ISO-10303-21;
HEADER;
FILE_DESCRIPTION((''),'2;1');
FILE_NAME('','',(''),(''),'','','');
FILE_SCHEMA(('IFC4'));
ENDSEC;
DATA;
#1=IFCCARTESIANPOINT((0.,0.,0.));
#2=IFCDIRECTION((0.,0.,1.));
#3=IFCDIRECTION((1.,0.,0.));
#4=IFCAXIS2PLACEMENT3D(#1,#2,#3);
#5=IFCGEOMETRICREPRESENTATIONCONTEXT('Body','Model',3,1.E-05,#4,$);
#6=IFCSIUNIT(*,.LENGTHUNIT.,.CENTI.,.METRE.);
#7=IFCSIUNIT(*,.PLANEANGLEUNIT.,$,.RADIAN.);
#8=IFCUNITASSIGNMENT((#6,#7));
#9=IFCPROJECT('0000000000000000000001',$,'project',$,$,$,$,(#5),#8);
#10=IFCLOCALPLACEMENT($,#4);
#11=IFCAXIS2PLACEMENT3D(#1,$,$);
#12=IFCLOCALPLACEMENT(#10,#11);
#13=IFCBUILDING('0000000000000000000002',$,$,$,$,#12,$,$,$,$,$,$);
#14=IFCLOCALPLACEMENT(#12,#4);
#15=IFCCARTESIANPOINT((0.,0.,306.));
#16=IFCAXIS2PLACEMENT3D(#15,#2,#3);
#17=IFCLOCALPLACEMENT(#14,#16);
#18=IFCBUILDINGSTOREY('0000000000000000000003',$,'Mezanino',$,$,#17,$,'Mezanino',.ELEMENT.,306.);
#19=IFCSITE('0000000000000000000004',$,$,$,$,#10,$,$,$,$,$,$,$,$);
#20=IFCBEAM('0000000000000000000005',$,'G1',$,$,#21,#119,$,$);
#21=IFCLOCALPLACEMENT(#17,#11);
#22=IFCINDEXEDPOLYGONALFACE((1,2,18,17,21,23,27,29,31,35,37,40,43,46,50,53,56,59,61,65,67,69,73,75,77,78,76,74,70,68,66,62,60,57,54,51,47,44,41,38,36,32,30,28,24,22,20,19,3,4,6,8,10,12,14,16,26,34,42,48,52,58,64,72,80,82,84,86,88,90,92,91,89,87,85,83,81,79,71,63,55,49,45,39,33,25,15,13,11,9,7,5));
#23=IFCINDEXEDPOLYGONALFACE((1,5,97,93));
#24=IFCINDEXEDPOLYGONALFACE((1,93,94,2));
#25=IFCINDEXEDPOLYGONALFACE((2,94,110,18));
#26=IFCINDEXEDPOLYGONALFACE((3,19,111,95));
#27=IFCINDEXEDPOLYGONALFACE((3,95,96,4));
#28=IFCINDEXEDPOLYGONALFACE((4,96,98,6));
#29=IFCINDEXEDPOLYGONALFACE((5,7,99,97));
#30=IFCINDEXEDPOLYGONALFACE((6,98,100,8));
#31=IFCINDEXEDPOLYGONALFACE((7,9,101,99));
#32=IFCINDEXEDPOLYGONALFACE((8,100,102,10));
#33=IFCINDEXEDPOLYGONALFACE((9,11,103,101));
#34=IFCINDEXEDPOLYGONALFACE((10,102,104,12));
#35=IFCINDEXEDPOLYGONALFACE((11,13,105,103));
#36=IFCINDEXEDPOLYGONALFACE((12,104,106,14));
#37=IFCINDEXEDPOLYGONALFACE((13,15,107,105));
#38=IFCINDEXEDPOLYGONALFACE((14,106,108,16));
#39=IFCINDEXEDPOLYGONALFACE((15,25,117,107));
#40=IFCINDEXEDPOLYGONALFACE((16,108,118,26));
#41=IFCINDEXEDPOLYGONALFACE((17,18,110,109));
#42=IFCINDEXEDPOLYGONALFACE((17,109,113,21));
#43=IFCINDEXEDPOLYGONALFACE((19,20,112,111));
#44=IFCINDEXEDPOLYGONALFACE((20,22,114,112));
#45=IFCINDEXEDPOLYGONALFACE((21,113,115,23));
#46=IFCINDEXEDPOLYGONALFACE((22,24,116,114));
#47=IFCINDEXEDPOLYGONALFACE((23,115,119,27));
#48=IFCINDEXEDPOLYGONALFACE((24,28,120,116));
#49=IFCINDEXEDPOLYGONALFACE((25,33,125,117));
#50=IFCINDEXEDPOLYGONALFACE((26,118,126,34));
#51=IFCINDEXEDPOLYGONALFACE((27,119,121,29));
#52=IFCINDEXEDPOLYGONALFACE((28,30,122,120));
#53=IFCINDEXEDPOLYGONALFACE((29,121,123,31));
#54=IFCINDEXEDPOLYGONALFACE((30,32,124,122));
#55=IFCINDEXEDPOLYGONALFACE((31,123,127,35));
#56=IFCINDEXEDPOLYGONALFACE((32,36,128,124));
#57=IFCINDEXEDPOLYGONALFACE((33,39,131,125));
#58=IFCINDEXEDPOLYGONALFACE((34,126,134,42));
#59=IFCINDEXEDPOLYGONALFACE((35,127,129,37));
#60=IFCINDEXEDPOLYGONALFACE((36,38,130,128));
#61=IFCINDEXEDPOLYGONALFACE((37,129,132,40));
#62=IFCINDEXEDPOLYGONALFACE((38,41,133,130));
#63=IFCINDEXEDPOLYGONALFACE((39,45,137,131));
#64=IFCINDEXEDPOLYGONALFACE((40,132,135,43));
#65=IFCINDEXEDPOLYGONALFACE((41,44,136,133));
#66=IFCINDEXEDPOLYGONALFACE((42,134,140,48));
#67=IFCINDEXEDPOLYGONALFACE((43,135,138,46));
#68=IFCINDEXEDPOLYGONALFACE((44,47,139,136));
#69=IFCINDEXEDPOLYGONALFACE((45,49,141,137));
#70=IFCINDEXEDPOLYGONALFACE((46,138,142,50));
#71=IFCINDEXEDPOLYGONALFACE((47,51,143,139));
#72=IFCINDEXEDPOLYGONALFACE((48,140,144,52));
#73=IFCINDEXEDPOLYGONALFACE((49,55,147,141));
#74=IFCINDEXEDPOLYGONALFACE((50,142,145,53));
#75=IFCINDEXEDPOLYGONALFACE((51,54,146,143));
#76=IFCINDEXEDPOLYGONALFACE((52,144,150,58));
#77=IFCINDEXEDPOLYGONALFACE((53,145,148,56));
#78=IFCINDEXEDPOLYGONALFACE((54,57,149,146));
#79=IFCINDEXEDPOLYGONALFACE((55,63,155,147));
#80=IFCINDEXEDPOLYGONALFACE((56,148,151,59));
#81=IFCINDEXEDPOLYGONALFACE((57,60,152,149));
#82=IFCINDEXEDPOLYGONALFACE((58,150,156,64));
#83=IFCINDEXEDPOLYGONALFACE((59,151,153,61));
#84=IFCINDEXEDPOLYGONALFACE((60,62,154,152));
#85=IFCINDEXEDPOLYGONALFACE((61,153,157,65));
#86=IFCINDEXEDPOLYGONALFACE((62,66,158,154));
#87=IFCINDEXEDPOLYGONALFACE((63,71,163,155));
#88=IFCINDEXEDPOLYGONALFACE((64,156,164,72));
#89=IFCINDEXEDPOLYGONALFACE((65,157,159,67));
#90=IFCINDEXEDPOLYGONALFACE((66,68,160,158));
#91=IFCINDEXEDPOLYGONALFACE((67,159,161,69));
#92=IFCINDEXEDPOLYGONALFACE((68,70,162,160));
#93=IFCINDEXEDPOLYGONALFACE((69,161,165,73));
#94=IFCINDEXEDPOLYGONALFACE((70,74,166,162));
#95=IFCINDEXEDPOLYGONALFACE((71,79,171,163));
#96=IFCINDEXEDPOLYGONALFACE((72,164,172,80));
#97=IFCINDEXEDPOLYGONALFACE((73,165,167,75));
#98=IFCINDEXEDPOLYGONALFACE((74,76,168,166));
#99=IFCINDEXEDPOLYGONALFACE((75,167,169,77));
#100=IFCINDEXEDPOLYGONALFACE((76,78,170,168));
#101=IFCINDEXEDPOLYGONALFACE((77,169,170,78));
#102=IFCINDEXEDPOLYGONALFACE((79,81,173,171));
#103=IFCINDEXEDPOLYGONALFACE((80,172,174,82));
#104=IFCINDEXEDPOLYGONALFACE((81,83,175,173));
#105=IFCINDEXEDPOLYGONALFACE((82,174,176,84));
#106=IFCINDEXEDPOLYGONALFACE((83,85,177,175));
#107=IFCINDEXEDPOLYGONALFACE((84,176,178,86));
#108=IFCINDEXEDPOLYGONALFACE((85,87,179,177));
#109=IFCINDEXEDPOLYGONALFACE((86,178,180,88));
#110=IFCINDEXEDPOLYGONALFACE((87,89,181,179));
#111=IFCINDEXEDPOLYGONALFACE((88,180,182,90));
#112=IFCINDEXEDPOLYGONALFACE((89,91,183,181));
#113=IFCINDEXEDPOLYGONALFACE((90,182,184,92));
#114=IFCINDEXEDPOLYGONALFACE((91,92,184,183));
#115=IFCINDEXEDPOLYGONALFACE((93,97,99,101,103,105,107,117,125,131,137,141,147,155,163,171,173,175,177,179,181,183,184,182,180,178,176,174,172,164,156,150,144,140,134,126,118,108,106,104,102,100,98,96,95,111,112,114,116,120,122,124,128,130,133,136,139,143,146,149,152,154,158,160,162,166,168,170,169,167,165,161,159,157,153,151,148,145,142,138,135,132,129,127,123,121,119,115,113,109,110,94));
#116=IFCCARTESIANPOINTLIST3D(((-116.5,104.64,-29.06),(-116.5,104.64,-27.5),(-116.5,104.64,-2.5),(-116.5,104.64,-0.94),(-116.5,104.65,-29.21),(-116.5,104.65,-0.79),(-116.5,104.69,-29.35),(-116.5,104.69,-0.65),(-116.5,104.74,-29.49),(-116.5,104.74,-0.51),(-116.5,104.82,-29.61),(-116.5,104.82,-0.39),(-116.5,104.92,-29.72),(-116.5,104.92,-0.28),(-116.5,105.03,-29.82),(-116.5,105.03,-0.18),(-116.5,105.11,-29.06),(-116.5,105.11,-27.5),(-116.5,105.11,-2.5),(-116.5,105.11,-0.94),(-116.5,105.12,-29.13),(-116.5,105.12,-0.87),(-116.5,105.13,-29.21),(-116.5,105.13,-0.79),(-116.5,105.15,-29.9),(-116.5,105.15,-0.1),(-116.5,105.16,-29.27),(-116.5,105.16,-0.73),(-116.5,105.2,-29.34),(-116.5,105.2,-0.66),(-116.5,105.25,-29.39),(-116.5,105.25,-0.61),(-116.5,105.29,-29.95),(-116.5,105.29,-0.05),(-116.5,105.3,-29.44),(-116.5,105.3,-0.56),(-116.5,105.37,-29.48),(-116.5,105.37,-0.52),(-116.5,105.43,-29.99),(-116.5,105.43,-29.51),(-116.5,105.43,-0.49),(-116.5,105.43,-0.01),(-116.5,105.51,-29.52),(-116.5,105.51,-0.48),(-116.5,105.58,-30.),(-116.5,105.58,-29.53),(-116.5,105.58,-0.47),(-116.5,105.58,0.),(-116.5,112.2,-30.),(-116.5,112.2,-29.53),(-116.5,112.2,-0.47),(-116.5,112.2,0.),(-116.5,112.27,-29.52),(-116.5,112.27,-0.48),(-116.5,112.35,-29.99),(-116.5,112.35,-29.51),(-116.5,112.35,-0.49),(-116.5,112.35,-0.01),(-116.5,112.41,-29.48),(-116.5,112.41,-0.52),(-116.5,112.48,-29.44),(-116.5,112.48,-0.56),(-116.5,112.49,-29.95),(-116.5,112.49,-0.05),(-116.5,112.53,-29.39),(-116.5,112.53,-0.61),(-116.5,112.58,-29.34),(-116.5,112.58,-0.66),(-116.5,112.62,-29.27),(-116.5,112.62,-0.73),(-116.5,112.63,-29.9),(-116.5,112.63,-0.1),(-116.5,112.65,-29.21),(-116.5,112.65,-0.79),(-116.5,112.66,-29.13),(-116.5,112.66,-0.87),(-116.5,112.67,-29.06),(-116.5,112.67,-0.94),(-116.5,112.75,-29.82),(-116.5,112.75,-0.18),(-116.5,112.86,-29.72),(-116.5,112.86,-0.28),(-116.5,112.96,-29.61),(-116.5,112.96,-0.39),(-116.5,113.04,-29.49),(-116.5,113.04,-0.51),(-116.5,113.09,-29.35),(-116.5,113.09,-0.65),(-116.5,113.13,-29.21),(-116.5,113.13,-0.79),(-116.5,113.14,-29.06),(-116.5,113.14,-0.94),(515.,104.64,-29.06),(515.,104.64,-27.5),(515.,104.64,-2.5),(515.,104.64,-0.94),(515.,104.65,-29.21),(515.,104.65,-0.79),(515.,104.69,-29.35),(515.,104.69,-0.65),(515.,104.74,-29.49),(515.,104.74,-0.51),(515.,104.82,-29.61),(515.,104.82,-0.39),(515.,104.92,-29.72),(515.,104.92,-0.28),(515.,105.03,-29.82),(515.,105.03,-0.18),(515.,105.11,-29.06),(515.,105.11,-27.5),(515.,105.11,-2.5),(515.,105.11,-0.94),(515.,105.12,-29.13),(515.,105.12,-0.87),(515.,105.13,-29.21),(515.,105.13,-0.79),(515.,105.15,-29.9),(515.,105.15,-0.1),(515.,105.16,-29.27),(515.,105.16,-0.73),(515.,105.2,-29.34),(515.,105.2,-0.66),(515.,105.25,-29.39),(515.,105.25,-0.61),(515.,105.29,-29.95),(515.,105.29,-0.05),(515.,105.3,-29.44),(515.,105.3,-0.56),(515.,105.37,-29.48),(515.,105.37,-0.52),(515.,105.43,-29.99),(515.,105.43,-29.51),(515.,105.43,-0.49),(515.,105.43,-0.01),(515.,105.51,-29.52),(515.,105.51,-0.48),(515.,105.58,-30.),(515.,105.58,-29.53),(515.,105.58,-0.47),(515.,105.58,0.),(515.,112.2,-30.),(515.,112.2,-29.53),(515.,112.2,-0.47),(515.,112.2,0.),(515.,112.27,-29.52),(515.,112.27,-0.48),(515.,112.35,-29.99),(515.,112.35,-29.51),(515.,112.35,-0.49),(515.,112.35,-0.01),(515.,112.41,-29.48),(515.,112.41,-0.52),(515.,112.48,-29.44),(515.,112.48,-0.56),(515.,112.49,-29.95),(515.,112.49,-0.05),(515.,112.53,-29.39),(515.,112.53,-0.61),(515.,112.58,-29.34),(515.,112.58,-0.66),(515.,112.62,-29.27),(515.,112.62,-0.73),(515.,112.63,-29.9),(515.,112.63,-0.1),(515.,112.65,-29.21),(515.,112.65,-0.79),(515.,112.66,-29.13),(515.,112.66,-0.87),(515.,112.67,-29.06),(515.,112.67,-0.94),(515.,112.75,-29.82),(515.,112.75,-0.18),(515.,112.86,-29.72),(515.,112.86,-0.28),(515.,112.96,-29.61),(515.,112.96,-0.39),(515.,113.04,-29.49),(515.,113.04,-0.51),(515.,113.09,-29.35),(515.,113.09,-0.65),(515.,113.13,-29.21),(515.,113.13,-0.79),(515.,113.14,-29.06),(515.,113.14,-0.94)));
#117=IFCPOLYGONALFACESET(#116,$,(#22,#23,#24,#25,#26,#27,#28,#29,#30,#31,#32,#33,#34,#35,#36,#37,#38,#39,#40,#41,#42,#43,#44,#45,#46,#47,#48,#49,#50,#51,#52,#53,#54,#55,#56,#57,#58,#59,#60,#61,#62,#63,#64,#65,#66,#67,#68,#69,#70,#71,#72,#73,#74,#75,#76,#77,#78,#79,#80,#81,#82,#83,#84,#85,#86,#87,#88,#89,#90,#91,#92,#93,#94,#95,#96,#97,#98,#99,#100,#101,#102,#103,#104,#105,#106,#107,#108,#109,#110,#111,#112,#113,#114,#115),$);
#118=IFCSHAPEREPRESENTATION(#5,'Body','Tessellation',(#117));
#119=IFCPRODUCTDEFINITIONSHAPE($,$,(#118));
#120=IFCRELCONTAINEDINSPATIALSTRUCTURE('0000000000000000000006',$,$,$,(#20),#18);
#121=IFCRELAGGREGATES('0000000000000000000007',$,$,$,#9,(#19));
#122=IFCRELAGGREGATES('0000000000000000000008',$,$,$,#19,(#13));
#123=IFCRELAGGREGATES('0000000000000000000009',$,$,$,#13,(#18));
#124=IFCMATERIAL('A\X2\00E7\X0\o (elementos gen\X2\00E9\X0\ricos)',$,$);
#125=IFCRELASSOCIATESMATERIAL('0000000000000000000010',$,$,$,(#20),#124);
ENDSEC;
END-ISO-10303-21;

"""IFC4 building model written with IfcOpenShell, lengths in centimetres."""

from ifc_helpers import new_model, si_unit, frame, origin, origin_with_axes, place, context, project, spatial, polyline, outline, extrude, material, element, save


model = new_model("IFC4")

# Units and contexts
model_context = context("Model", 3, precision=1e-05, world=origin_with_axes(), identifier="Body")
ifc_project = project(units=[si_unit("LENGTHUNIT", "METRE", prefix="CENTI"), si_unit("PLANEANGLEUNIT", "RADIAN")], contexts=[model_context])

# Site, building, storey
site_placement = place(None, origin_with_axes())
site = spatial("IfcSite", under=ifc_project, at=site_placement)
building_placement = place(site_placement, origin())
building = spatial("IfcBuilding", under=site, at=building_placement)
placement = place(building_placement, origin_with_axes())
storey_placement = place(placement, frame((0.0, 0.0, 306.0), z_axis=(0.0, 0.0, 1.0), x_axis=(1.0, 0.0, 0.0)))
storey = spatial("IfcBuildingStorey", under=building, at=storey_placement, Name="Mezanino", LongName="Mezanino", CompositionType="ELEMENT", Elevation=306.0)

# Beam
ifc_material_1 = material(Name="Aço (elementos genéricos)")
beam_1_placement = place(storey_placement, frame((199.25, 108.89, 0.0), z_axis=(0.0, 0.0, 1.0), x_axis=(1.0, 0.0, 0.0)))
element("IfcBeam", 1, at=beam_1_placement, inside=storey, material=ifc_material_1, Name="G1", context=model_context, shape_type="SolidModel", body=[
    extrude(outline(polyline([(4.25, 14.06), (4.24, 14.21), (4.2, 14.35), (4.15, 14.49), (4.07, 14.61), (3.97, 14.72), (3.86, 14.82), (3.74, 14.9), (3.6, 14.95), (3.46, 14.99), (3.31, 15.0), (-3.31, 15.0), (-3.46, 14.99), (-3.6, 14.95), (-3.74, 14.9), (-3.86, 14.82), (-3.97, 14.72), (-4.07, 14.61), (-4.15, 14.49), (-4.2, 14.35), (-4.24, 14.21), (-4.25, 14.06), (-4.25, 12.5), (-3.78, 12.5), (-3.78, 14.06), (-3.77, 14.13), (-3.76, 14.21), (-3.73, 14.27), (-3.69, 14.34), (-3.64, 14.39), (-3.59, 14.44), (-3.52, 14.48), (-3.46, 14.51), (-3.38, 14.52), (-3.31, 14.53), (3.31, 14.53), (3.38, 14.52), (3.46, 14.51), (3.52, 14.48), (3.59, 14.44), (3.64, 14.39), (3.69, 14.34), (3.73, 14.27), (3.76, 14.21), (3.77, 14.13), (3.78, 14.06), (3.78, -14.06), (3.77, -14.13), (3.76, -14.21), (3.73, -14.27), (3.69, -14.34), (3.64, -14.39), (3.59, -14.44), (3.52, -14.48), (3.46, -14.51), (3.38, -14.52), (3.31, -14.53), (-3.31, -14.53), (-3.38, -14.52), (-3.46, -14.51), (-3.52, -14.48), (-3.59, -14.44), (-3.64, -14.39), (-3.69, -14.34), (-3.73, -14.27), (-3.76, -14.21), (-3.77, -14.13), (-3.78, -14.06), (-3.78, -12.5), (-4.25, -12.5), (-4.25, -14.06), (-4.24, -14.21), (-4.2, -14.35), (-4.15, -14.49), (-4.07, -14.61), (-3.97, -14.72), (-3.86, -14.82), (-3.74, -14.9), (-3.6, -14.95), (-3.46, -14.99), (-3.31, -15.0), (3.31, -15.0), (3.46, -14.99), (3.6, -14.95), (3.74, -14.9), (3.86, -14.82), (3.97, -14.72), (4.07, -14.61), (4.15, -14.49), (4.2, -14.35), (4.24, -14.21), (4.25, -14.06), (4.25, 14.06)])), frame((-315.75, 0.0, -15.0), z_axis=(1.0, 0.0, 0.0), x_axis=(0.0, 1.0, 0.0)), (0.0, 0.0, 1.0), 631.5),
])

save(model, "model.ifc")
